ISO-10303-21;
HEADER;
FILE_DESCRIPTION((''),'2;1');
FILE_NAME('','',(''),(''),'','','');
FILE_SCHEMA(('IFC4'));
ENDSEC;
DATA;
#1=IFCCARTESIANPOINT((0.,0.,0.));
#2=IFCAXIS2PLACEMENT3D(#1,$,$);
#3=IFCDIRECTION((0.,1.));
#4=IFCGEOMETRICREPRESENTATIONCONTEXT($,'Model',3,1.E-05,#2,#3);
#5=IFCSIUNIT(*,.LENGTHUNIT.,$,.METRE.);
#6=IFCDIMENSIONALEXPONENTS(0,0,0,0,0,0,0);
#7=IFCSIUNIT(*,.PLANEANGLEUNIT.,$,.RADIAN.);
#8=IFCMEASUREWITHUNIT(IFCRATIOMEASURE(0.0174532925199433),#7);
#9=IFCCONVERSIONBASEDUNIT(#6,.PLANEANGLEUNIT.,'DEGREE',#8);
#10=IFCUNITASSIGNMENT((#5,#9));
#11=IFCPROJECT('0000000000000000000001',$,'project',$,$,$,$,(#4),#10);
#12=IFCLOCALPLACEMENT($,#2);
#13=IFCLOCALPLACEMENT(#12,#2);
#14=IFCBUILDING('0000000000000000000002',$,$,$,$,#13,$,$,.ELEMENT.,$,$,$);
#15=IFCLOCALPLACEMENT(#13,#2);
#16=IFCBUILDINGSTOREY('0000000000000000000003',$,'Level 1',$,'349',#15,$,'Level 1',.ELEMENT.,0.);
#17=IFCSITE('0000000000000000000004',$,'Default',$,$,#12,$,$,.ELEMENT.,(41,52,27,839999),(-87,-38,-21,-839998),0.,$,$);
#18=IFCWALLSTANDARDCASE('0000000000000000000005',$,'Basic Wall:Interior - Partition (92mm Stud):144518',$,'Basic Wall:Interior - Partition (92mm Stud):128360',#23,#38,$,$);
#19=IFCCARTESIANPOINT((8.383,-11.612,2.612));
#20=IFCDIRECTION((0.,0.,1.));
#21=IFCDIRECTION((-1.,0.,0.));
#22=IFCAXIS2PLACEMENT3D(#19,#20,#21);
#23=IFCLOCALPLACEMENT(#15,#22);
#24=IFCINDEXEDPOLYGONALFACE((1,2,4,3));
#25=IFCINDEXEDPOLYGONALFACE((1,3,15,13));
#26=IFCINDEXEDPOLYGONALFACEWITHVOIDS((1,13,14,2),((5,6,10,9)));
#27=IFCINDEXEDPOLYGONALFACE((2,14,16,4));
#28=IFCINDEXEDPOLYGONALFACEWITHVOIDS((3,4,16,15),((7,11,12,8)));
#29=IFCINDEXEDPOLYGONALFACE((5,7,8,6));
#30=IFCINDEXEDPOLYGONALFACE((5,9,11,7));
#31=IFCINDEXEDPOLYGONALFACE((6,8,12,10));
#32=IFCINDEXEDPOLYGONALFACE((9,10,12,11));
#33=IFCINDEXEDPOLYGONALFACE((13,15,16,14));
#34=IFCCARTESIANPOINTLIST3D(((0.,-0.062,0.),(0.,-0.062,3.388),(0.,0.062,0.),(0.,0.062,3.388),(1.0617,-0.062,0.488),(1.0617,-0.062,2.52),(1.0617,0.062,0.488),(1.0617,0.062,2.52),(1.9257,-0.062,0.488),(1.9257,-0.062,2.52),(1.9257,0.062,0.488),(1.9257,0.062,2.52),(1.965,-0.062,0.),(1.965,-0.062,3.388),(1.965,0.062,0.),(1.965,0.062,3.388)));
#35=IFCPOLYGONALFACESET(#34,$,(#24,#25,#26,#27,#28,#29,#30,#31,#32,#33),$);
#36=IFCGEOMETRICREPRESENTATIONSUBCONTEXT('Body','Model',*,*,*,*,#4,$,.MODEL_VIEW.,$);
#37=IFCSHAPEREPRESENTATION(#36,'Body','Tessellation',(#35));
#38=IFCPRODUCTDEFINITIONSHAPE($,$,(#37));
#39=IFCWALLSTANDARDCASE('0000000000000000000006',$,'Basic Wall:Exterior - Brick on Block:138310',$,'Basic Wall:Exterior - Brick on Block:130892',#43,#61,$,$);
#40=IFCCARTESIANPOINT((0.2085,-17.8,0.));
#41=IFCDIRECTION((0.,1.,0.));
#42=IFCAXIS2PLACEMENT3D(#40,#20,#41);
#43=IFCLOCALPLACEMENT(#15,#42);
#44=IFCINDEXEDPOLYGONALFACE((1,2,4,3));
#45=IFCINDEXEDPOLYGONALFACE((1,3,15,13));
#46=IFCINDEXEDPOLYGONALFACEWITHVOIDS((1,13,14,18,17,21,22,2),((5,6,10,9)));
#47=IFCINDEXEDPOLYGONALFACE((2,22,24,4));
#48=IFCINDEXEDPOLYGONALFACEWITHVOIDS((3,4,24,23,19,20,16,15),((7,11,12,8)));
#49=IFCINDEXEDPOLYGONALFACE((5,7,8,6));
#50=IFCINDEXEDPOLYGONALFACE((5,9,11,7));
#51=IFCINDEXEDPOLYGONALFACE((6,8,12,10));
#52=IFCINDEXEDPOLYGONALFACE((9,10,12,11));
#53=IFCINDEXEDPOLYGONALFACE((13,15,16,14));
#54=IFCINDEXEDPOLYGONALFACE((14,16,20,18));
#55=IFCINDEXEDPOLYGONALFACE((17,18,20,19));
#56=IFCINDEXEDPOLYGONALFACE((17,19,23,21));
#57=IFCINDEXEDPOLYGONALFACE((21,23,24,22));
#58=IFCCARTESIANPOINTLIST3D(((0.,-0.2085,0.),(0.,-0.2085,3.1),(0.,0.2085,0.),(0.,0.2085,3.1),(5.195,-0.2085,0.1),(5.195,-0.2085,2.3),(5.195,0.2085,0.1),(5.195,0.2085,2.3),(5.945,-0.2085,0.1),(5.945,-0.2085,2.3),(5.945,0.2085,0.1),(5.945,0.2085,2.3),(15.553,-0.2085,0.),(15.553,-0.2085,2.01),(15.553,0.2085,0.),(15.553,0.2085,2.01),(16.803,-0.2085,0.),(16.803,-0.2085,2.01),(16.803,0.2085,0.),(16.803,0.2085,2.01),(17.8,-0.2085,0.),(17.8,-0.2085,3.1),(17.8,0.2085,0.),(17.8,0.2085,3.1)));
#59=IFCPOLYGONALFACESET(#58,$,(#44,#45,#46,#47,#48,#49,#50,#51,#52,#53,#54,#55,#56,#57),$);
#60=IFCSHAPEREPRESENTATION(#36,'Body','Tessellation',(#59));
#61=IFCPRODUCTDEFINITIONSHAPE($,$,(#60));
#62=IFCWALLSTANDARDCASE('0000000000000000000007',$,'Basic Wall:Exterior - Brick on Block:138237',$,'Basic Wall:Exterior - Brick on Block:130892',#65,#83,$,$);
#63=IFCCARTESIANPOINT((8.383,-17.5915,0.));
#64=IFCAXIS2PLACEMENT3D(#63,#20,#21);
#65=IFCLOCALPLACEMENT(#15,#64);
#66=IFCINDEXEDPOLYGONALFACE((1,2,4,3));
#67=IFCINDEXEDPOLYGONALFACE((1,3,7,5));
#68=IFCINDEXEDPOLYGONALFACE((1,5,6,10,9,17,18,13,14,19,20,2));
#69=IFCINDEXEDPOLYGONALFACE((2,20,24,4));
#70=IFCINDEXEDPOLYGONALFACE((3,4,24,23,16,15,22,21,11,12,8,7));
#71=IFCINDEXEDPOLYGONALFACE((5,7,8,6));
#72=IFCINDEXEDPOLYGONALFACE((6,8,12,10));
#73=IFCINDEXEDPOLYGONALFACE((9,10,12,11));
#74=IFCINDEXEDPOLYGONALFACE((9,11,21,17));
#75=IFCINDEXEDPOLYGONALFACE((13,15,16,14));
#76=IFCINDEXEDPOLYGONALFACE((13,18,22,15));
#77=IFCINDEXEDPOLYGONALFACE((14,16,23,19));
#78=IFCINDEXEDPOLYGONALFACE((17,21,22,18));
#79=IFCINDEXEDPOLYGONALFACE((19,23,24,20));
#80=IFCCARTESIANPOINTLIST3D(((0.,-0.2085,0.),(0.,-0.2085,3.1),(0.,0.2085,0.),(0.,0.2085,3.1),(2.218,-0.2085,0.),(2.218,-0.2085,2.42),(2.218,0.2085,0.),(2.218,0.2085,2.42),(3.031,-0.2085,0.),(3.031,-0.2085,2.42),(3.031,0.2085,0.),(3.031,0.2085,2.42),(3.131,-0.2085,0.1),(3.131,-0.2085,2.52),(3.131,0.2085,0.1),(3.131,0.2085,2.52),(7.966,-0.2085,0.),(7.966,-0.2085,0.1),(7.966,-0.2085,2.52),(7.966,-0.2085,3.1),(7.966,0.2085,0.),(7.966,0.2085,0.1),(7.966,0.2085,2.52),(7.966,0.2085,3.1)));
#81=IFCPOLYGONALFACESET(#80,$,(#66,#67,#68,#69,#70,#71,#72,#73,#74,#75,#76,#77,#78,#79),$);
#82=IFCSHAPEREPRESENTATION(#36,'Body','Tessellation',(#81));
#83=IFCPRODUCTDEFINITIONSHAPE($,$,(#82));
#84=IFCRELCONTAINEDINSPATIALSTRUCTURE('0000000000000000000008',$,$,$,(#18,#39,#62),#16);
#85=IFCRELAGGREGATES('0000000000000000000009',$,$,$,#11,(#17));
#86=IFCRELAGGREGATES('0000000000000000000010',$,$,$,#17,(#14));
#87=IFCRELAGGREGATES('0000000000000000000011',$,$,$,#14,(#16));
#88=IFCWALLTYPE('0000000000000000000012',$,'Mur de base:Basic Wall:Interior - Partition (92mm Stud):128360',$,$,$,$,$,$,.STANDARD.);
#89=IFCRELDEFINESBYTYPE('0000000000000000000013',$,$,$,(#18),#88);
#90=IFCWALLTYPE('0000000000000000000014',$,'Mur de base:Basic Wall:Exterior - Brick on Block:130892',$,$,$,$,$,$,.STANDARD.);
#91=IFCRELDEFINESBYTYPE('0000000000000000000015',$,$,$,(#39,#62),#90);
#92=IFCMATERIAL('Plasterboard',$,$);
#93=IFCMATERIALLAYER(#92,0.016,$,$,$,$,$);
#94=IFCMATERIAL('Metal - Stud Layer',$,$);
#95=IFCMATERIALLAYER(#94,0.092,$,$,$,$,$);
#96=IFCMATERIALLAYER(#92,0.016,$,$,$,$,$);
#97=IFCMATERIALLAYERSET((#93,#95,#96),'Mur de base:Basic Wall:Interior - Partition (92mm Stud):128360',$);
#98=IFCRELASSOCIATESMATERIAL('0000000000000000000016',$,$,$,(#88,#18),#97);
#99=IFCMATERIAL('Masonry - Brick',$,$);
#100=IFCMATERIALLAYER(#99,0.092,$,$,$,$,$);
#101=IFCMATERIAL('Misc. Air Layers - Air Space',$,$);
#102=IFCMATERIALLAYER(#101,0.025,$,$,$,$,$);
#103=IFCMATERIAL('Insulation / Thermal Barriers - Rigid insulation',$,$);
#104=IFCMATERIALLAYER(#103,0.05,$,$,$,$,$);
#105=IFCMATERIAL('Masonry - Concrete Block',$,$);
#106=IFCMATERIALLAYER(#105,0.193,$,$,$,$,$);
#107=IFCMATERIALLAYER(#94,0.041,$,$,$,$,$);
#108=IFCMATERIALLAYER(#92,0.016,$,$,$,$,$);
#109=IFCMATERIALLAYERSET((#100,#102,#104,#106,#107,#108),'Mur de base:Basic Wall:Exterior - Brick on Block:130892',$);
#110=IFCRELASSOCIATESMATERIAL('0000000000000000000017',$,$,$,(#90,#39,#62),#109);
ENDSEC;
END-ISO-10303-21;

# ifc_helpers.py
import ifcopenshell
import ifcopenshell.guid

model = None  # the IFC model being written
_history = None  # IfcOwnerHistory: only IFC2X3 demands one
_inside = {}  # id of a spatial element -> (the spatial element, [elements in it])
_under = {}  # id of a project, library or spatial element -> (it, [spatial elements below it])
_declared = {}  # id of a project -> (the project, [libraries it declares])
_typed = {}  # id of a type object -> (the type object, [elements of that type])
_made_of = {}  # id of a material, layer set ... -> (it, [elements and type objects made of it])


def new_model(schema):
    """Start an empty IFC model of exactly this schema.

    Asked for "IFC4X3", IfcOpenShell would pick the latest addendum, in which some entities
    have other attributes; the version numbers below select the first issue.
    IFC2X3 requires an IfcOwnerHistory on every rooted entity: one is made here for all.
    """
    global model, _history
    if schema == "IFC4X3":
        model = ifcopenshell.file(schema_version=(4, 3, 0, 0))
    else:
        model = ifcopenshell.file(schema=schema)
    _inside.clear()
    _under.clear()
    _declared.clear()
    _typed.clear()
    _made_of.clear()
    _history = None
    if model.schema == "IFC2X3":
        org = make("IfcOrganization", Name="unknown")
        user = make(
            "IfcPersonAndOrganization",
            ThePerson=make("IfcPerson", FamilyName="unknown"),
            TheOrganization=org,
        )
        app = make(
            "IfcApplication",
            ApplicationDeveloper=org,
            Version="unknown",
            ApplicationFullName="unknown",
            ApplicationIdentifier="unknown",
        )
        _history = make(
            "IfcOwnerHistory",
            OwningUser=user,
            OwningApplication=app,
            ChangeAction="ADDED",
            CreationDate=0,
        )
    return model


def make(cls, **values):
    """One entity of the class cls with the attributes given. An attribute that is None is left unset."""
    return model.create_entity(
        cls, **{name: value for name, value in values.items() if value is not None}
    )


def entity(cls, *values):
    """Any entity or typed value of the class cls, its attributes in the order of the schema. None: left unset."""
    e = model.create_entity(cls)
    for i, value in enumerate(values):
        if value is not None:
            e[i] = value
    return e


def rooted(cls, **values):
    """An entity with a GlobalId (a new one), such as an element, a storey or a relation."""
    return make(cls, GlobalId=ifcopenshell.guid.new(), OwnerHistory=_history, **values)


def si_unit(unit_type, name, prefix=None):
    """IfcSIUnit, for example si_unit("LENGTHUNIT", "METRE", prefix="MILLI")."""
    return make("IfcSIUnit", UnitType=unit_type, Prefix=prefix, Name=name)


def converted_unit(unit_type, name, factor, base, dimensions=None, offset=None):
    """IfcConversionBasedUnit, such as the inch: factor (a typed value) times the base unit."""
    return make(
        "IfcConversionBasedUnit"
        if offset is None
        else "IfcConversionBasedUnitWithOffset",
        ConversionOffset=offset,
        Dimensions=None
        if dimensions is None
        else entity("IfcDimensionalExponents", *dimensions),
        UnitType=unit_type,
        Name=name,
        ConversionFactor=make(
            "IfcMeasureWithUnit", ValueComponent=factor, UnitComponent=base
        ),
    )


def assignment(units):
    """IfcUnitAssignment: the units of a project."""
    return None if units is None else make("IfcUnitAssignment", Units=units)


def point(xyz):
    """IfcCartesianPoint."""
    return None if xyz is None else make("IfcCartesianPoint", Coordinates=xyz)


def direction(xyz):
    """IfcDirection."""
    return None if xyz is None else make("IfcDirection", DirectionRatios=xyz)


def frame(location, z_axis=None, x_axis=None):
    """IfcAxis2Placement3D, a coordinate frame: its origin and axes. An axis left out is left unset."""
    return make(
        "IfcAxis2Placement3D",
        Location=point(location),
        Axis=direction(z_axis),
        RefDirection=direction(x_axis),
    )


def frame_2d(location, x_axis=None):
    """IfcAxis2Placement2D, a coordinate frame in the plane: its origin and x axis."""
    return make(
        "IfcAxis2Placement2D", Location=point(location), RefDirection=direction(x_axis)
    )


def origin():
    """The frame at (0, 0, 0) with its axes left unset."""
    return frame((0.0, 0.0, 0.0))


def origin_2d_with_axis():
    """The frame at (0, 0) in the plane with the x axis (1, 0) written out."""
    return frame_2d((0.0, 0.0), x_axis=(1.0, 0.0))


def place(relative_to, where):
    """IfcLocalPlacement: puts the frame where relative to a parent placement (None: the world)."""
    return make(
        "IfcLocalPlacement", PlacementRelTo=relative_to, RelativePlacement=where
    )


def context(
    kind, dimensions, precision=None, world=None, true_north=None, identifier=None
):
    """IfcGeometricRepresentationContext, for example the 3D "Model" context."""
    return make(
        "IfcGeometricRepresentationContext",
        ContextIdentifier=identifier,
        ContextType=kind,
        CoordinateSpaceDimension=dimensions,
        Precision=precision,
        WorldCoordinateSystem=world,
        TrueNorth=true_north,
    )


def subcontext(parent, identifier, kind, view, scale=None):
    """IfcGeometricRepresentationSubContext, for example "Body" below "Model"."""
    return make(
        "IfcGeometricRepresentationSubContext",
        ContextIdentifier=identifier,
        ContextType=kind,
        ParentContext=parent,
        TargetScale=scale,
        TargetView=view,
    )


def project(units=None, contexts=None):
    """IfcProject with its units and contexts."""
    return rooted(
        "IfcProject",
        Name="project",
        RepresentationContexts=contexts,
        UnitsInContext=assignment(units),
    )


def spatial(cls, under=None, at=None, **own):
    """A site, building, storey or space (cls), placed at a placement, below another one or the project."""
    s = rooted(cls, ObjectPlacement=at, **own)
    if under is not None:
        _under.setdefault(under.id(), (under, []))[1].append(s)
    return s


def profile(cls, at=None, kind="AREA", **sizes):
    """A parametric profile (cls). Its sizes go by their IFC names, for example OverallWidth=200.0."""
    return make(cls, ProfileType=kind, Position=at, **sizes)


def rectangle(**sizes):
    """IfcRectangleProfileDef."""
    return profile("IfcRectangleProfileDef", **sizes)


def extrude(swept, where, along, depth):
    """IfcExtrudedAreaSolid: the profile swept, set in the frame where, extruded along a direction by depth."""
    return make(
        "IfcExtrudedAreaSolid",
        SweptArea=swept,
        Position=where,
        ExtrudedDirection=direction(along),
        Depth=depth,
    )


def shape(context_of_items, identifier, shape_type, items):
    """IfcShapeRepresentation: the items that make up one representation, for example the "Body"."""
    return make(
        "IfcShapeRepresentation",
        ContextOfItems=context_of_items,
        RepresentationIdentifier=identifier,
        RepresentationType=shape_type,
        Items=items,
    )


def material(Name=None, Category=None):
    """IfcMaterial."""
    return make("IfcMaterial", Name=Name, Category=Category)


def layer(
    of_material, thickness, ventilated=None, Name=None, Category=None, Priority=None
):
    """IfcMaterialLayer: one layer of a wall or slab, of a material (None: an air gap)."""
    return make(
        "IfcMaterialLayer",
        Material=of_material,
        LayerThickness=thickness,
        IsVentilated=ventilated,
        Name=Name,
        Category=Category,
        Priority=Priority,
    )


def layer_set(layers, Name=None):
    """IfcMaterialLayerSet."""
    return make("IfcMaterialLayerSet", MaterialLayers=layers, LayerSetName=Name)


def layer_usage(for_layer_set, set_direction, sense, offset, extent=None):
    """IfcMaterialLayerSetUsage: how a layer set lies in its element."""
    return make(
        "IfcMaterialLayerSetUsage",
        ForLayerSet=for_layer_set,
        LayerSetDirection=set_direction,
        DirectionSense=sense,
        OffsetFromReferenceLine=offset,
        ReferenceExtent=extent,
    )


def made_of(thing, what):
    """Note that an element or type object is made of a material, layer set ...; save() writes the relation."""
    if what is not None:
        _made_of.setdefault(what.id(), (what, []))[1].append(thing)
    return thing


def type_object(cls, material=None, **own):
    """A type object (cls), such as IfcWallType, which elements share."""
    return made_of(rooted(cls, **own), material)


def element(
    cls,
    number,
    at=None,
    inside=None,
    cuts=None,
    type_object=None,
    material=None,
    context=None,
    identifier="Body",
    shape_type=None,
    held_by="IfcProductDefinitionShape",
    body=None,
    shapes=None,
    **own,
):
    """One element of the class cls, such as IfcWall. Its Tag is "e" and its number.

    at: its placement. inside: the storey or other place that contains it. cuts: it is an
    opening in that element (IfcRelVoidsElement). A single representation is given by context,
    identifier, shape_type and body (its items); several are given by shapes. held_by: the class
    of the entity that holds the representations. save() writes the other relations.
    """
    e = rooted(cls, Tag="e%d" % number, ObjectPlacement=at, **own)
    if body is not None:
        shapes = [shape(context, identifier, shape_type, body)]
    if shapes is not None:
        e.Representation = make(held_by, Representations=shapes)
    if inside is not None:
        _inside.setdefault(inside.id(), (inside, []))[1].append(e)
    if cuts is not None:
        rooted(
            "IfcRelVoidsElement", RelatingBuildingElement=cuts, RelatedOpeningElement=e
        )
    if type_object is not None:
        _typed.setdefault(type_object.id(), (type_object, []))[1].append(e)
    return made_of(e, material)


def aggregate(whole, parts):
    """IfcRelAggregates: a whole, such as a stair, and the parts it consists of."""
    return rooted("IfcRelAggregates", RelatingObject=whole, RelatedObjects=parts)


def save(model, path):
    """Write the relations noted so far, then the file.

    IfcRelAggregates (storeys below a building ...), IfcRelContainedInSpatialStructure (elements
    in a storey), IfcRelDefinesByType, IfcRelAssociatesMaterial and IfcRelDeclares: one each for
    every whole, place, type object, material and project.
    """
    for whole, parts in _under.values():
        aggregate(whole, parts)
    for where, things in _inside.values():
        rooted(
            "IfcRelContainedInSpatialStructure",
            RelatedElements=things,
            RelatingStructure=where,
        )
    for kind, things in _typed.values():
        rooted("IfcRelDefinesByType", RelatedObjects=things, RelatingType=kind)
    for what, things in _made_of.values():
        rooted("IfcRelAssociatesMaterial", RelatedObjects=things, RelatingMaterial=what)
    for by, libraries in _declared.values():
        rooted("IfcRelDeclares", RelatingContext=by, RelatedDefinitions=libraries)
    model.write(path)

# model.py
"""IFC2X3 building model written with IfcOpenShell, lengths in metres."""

from ifc_helpers import new_model, entity, si_unit, converted_unit, direction, frame, frame_2d, origin, origin_2d_with_axis, place, context, subcontext, project, spatial, rectangle, extrude, material, layer, layer_set, layer_usage, type_object, element, save


model = new_model("IFC2X3")

# Units and contexts
model_context = context("Model", 3, precision=1e-05, world=origin(), true_north=direction((0.0, 1.0)))
body_context = subcontext(model_context, "Body", "Model", "MODEL_VIEW")
ifc_project = project(units=[si_unit("LENGTHUNIT", "METRE"), converted_unit("PLANEANGLEUNIT", "DEGREE", entity("IfcRatioMeasure", 0.0174532925199433), si_unit("PLANEANGLEUNIT", "RADIAN"), dimensions=[0, 0, 0, 0, 0, 0, 0])], contexts=[model_context])

# Site, building, storey
site_placement = place(None, origin())
site = spatial("IfcSite", under=ifc_project, at=site_placement, Name="Default", CompositionType="ELEMENT", RefLatitude=(41, 52, 27, 839999), RefLongitude=(-87, -38, -21, -839998), RefElevation=0.0)
building_placement = place(site_placement, origin())
building = spatial("IfcBuilding", under=site, at=building_placement, CompositionType="ELEMENT")
storey_placement = place(building_placement, origin())
storey = spatial("IfcBuildingStorey", under=building, at=storey_placement, Name="Level 1", ObjectType="349", LongName="Level 1", CompositionType="ELEMENT", Elevation=0.0)

# Shared definitions
ifc_material_1 = material(Name="Plasterboard")
ifc_material_2 = material(Name="Metal - Stud Layer")
ifc_material_3 = material(Name="Masonry - Concrete Block")
ifc_material_4 = material(Name="Misc. Air Layers - Air Space")

# Shared definitions
ifc_layer_1 = layer(ifc_material_1, 0.016)
ifc_layer_2 = layer(ifc_material_2, 0.092)
ifc_layer_3 = layer(ifc_material_1, 0.016)
ifc_layer_set_1 = layer_set([ifc_layer_1, ifc_layer_2, ifc_layer_3], Name="Mur de base:Basic Wall:Interior - Partition (92mm Stud):128360")
wall_type_1 = type_object("IfcWallType", Name="Mur de base:Basic Wall:Interior - Partition (92mm Stud):128360", PredefinedType="STANDARD", material=ifc_layer_set_1)

# Wall, opening
ifc_layer_usage_1 = layer_usage(ifc_layer_set_1, "AXIS2", "NEGATIVE", 0.062)
wall_1_placement = place(storey_placement, frame((8.383, -11.612, 2.612), z_axis=(0.0, 0.0, 1.0), x_axis=(-1.0, 0.0, 0.0)))
wall_1 = element("IfcWallStandardCase", 1, at=wall_1_placement, inside=storey, type_object=wall_type_1, material=ifc_layer_usage_1, Name="Basic Wall:Interior - Partition (92mm Stud):144518", ObjectType="Basic Wall:Interior - Partition (92mm Stud):128360", context=body_context, shape_type="SweptSolid", body=[
    extrude(rectangle(XDim=1.965, YDim=0.124, at=frame_2d((0.9825, 0.0), x_axis=(-1.0, 0.0))), origin(), (0.0, 0.0, 1.0), 3.388),
])
opening_1_placement = place(wall_1_placement, origin())
element("IfcOpeningElement", 2, at=opening_1_placement, cuts=wall_1, ObjectType="Opening", context=body_context, shape_type="SweptSolid", body=[
    extrude(rectangle(XDim=2.032, YDim=0.864, at=frame_2d((0.0, 0.0), x_axis=(1.0, 0.0))), frame((1.4937, -0.0632, 1.504), z_axis=(0.0, 1.0, 0.0), x_axis=(0.0, 0.0, -1.0)), (0.0, 0.0, 1.0), 0.1265),
])

# Walls, openings
ifc_material_5 = material(Name="Masonry - Brick")
ifc_layer_4 = layer(ifc_material_5, 0.092)
ifc_layer_5 = layer(ifc_material_4, 0.025)
ifc_material_6 = material(Name="Insulation / Thermal Barriers - Rigid insulation")
ifc_layer_6 = layer(ifc_material_6, 0.05)
ifc_layer_7 = layer(ifc_material_3, 0.193)
ifc_layer_8 = layer(ifc_material_2, 0.041)
ifc_layer_9 = layer(ifc_material_1, 0.016)
ifc_layer_set_2 = layer_set([ifc_layer_4, ifc_layer_5, ifc_layer_6, ifc_layer_7, ifc_layer_8, ifc_layer_9], Name="Mur de base:Basic Wall:Exterior - Brick on Block:130892")
ifc_layer_usage_2 = layer_usage(ifc_layer_set_2, "AXIS2", "NEGATIVE", 0.2085)
wall_type_2 = type_object("IfcWallType", Name="Mur de base:Basic Wall:Exterior - Brick on Block:130892", PredefinedType="STANDARD", material=ifc_layer_set_2)
wall_2_placement = place(storey_placement, frame((0.2085, -17.8, 0.0), z_axis=(0.0, 0.0, 1.0), x_axis=(0.0, 1.0, 0.0)))
wall_2 = element("IfcWallStandardCase", 3, at=wall_2_placement, inside=storey, type_object=wall_type_2, material=ifc_layer_usage_2, Name="Basic Wall:Exterior - Brick on Block:138310", ObjectType="Basic Wall:Exterior - Brick on Block:130892", context=body_context, shape_type="SweptSolid", body=[
    extrude(rectangle(XDim=17.8, YDim=0.417, at=frame_2d((8.9, 0.0), x_axis=(-1.0, 0.0))), origin(), (0.0, 0.0, 1.0), 3.1),
])
opening_2_placement = place(wall_2_placement, origin())
element("IfcOpeningElement", 4, at=opening_2_placement, cuts=wall_2, ObjectType="Opening", context=body_context, shape_type="SweptSolid", body=[
    extrude(rectangle(XDim=2.01, YDim=1.25, at=origin_2d_with_axis()), frame((16.178, -0.2127, 1.005), z_axis=(0.0, 1.0, 0.0), x_axis=(0.0, 0.0, -1.0)), (0.0, 0.0, 1.0), 0.4253),
])
opening_3_placement = place(wall_2_placement, origin())
element("IfcOpeningElement", 5, at=opening_3_placement, cuts=wall_2, ObjectType="Opening", context=body_context, shape_type="SweptSolid", body=[
    extrude(rectangle(XDim=2.2, YDim=0.75, at=frame_2d((0.0, 0.0), x_axis=(0.0, 1.0))), frame((5.57, -0.2127, 1.2), z_axis=(0.0, 1.0, 0.0), x_axis=(1.0, 0.0, 0.0)), (0.0, 0.0, 1.0), 0.4253),
])
ifc_layer_usage_3 = layer_usage(ifc_layer_set_2, "AXIS2", "NEGATIVE", 0.2085)
wall_3_placement = place(storey_placement, frame((8.383, -17.5915, 0.0), z_axis=(0.0, 0.0, 1.0), x_axis=(-1.0, 0.0, 0.0)))
wall_3 = element("IfcWallStandardCase", 6, at=wall_3_placement, inside=storey, type_object=wall_type_2, material=ifc_layer_usage_3, Name="Basic Wall:Exterior - Brick on Block:138237", ObjectType="Basic Wall:Exterior - Brick on Block:130892", context=body_context, shape_type="SweptSolid", body=[
    extrude(rectangle(XDim=7.966, YDim=0.417, at=frame_2d((3.983, 0.0), x_axis=(-1.0, 0.0))), origin(), (0.0, 0.0, 1.0), 3.1),
])
opening_4_placement = place(wall_3_placement, origin())
element("IfcOpeningElement", 7, at=opening_4_placement, cuts=wall_3, ObjectType="Opening", context=body_context, shape_type="SweptSolid", body=[
    extrude(rectangle(XDim=2.42, YDim=0.813, at=origin_2d_with_axis()), frame((2.6245, -0.2127, 1.21), z_axis=(0.0, 1.0, 0.0), x_axis=(0.0, 0.0, 1.0)), (0.0, 0.0, 1.0), 0.4253),
])
opening_5_placement = place(wall_3_placement, origin())
element("IfcOpeningElement", 8, at=opening_5_placement, cuts=wall_3, ObjectType="Opening", context=body_context, shape_type="SweptSolid", body=[
    extrude(rectangle(XDim=2.42, YDim=4.835, at=frame_2d((0.0, 0.0), x_axis=(0.0, 1.0))), frame((5.5485, -0.2127, 1.31), z_axis=(0.0, 1.0, 0.0), x_axis=(1.0, 0.0, 0.0)), (0.0, 0.0, 1.0), 0.4253),
])

save(model, "model.ifc")
